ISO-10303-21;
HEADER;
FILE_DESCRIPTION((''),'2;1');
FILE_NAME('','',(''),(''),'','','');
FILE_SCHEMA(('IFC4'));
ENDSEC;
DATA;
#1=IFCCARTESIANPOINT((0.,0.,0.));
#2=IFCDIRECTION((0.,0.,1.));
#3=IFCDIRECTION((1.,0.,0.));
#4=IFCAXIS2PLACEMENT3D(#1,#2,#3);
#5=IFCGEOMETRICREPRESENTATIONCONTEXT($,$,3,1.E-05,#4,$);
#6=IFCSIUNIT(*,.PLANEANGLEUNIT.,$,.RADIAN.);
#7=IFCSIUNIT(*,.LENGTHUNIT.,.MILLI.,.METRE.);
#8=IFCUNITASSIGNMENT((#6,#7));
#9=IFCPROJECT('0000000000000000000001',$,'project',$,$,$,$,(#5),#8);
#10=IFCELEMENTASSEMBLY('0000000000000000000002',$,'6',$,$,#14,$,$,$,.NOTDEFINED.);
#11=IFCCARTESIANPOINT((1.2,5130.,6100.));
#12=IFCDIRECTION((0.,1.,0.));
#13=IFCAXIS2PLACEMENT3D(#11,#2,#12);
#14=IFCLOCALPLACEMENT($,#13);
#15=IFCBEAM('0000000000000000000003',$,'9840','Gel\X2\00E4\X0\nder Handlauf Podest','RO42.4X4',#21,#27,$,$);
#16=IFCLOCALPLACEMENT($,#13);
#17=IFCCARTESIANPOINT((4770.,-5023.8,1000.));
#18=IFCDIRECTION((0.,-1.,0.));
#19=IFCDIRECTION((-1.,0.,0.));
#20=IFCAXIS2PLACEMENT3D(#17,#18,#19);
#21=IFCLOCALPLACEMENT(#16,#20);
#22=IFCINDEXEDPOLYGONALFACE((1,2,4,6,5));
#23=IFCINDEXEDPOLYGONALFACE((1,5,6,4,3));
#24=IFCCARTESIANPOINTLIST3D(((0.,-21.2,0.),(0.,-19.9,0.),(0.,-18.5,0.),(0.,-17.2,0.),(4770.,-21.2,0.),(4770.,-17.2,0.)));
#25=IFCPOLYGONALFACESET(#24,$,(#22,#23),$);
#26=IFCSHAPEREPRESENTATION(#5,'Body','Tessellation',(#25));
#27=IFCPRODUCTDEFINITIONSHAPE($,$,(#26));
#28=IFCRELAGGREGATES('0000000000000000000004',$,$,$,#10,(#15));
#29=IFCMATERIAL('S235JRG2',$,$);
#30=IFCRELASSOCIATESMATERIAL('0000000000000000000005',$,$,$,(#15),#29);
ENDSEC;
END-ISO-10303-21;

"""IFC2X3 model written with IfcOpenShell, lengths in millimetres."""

from ifc_helpers import new_model, si_unit, frame, origin_with_axes, place, context, project, polyline, outline, extrude, material, element, aggregate, save


model = new_model("IFC2X3")

# Units and contexts
context_of_model = context(None, 3, precision=1e-05, world=origin_with_axes())
ifc_project = project(units=[si_unit("PLANEANGLEUNIT", "RADIAN"), si_unit("LENGTHUNIT", "METRE", prefix="MILLI")], contexts=[context_of_model])

# Shared definitions
ifc_material = material(Name="S235JRG2")

# Element assembly, beam
assembly_1_placement = place(None, frame((1.2, 5130.0, 6100.0), z_axis=(0.0, 0.0, 1.0), x_axis=(0.0, 1.0, 0.0)))
assembly_1 = element("IfcElementAssembly", 1, at=assembly_1_placement, Name="6", PredefinedType="NOTDEFINED")
placement_1 = place(None, frame((1.2, 5130.0, 6100.0), z_axis=(0.0, 0.0, 1.0), x_axis=(0.0, 1.0, 0.0)))
beam_1_placement = place(placement_1, frame((4770.0, -5023.8, 1000.0), z_axis=(0.0, -1.0, 0.0), x_axis=(-1.0, 0.0, 0.0)))
beam_1 = element("IfcBeam", 2, at=beam_1_placement, material=ifc_material, Name="9840", Description="Geländer Handlauf Podest", ObjectType="RO42.4X4", context=context_of_model, shape_type="SweptSolid", body=[
    extrude(outline(polyline([(-21.2, 0.0), (-21.2, 0.0), (-17.2, 0.0), (-17.2, 0.0), (-21.2, 0.0)])), frame((0.0, 0.0, 0.0), z_axis=(1.0, 0.0, 0.0), x_axis=(0.0, 1.0, 0.0)), (0.0, 0.0, 1.0), 4770.0),
])
aggregate(assembly_1, [beam_1])

save(model, "model.ifc")
